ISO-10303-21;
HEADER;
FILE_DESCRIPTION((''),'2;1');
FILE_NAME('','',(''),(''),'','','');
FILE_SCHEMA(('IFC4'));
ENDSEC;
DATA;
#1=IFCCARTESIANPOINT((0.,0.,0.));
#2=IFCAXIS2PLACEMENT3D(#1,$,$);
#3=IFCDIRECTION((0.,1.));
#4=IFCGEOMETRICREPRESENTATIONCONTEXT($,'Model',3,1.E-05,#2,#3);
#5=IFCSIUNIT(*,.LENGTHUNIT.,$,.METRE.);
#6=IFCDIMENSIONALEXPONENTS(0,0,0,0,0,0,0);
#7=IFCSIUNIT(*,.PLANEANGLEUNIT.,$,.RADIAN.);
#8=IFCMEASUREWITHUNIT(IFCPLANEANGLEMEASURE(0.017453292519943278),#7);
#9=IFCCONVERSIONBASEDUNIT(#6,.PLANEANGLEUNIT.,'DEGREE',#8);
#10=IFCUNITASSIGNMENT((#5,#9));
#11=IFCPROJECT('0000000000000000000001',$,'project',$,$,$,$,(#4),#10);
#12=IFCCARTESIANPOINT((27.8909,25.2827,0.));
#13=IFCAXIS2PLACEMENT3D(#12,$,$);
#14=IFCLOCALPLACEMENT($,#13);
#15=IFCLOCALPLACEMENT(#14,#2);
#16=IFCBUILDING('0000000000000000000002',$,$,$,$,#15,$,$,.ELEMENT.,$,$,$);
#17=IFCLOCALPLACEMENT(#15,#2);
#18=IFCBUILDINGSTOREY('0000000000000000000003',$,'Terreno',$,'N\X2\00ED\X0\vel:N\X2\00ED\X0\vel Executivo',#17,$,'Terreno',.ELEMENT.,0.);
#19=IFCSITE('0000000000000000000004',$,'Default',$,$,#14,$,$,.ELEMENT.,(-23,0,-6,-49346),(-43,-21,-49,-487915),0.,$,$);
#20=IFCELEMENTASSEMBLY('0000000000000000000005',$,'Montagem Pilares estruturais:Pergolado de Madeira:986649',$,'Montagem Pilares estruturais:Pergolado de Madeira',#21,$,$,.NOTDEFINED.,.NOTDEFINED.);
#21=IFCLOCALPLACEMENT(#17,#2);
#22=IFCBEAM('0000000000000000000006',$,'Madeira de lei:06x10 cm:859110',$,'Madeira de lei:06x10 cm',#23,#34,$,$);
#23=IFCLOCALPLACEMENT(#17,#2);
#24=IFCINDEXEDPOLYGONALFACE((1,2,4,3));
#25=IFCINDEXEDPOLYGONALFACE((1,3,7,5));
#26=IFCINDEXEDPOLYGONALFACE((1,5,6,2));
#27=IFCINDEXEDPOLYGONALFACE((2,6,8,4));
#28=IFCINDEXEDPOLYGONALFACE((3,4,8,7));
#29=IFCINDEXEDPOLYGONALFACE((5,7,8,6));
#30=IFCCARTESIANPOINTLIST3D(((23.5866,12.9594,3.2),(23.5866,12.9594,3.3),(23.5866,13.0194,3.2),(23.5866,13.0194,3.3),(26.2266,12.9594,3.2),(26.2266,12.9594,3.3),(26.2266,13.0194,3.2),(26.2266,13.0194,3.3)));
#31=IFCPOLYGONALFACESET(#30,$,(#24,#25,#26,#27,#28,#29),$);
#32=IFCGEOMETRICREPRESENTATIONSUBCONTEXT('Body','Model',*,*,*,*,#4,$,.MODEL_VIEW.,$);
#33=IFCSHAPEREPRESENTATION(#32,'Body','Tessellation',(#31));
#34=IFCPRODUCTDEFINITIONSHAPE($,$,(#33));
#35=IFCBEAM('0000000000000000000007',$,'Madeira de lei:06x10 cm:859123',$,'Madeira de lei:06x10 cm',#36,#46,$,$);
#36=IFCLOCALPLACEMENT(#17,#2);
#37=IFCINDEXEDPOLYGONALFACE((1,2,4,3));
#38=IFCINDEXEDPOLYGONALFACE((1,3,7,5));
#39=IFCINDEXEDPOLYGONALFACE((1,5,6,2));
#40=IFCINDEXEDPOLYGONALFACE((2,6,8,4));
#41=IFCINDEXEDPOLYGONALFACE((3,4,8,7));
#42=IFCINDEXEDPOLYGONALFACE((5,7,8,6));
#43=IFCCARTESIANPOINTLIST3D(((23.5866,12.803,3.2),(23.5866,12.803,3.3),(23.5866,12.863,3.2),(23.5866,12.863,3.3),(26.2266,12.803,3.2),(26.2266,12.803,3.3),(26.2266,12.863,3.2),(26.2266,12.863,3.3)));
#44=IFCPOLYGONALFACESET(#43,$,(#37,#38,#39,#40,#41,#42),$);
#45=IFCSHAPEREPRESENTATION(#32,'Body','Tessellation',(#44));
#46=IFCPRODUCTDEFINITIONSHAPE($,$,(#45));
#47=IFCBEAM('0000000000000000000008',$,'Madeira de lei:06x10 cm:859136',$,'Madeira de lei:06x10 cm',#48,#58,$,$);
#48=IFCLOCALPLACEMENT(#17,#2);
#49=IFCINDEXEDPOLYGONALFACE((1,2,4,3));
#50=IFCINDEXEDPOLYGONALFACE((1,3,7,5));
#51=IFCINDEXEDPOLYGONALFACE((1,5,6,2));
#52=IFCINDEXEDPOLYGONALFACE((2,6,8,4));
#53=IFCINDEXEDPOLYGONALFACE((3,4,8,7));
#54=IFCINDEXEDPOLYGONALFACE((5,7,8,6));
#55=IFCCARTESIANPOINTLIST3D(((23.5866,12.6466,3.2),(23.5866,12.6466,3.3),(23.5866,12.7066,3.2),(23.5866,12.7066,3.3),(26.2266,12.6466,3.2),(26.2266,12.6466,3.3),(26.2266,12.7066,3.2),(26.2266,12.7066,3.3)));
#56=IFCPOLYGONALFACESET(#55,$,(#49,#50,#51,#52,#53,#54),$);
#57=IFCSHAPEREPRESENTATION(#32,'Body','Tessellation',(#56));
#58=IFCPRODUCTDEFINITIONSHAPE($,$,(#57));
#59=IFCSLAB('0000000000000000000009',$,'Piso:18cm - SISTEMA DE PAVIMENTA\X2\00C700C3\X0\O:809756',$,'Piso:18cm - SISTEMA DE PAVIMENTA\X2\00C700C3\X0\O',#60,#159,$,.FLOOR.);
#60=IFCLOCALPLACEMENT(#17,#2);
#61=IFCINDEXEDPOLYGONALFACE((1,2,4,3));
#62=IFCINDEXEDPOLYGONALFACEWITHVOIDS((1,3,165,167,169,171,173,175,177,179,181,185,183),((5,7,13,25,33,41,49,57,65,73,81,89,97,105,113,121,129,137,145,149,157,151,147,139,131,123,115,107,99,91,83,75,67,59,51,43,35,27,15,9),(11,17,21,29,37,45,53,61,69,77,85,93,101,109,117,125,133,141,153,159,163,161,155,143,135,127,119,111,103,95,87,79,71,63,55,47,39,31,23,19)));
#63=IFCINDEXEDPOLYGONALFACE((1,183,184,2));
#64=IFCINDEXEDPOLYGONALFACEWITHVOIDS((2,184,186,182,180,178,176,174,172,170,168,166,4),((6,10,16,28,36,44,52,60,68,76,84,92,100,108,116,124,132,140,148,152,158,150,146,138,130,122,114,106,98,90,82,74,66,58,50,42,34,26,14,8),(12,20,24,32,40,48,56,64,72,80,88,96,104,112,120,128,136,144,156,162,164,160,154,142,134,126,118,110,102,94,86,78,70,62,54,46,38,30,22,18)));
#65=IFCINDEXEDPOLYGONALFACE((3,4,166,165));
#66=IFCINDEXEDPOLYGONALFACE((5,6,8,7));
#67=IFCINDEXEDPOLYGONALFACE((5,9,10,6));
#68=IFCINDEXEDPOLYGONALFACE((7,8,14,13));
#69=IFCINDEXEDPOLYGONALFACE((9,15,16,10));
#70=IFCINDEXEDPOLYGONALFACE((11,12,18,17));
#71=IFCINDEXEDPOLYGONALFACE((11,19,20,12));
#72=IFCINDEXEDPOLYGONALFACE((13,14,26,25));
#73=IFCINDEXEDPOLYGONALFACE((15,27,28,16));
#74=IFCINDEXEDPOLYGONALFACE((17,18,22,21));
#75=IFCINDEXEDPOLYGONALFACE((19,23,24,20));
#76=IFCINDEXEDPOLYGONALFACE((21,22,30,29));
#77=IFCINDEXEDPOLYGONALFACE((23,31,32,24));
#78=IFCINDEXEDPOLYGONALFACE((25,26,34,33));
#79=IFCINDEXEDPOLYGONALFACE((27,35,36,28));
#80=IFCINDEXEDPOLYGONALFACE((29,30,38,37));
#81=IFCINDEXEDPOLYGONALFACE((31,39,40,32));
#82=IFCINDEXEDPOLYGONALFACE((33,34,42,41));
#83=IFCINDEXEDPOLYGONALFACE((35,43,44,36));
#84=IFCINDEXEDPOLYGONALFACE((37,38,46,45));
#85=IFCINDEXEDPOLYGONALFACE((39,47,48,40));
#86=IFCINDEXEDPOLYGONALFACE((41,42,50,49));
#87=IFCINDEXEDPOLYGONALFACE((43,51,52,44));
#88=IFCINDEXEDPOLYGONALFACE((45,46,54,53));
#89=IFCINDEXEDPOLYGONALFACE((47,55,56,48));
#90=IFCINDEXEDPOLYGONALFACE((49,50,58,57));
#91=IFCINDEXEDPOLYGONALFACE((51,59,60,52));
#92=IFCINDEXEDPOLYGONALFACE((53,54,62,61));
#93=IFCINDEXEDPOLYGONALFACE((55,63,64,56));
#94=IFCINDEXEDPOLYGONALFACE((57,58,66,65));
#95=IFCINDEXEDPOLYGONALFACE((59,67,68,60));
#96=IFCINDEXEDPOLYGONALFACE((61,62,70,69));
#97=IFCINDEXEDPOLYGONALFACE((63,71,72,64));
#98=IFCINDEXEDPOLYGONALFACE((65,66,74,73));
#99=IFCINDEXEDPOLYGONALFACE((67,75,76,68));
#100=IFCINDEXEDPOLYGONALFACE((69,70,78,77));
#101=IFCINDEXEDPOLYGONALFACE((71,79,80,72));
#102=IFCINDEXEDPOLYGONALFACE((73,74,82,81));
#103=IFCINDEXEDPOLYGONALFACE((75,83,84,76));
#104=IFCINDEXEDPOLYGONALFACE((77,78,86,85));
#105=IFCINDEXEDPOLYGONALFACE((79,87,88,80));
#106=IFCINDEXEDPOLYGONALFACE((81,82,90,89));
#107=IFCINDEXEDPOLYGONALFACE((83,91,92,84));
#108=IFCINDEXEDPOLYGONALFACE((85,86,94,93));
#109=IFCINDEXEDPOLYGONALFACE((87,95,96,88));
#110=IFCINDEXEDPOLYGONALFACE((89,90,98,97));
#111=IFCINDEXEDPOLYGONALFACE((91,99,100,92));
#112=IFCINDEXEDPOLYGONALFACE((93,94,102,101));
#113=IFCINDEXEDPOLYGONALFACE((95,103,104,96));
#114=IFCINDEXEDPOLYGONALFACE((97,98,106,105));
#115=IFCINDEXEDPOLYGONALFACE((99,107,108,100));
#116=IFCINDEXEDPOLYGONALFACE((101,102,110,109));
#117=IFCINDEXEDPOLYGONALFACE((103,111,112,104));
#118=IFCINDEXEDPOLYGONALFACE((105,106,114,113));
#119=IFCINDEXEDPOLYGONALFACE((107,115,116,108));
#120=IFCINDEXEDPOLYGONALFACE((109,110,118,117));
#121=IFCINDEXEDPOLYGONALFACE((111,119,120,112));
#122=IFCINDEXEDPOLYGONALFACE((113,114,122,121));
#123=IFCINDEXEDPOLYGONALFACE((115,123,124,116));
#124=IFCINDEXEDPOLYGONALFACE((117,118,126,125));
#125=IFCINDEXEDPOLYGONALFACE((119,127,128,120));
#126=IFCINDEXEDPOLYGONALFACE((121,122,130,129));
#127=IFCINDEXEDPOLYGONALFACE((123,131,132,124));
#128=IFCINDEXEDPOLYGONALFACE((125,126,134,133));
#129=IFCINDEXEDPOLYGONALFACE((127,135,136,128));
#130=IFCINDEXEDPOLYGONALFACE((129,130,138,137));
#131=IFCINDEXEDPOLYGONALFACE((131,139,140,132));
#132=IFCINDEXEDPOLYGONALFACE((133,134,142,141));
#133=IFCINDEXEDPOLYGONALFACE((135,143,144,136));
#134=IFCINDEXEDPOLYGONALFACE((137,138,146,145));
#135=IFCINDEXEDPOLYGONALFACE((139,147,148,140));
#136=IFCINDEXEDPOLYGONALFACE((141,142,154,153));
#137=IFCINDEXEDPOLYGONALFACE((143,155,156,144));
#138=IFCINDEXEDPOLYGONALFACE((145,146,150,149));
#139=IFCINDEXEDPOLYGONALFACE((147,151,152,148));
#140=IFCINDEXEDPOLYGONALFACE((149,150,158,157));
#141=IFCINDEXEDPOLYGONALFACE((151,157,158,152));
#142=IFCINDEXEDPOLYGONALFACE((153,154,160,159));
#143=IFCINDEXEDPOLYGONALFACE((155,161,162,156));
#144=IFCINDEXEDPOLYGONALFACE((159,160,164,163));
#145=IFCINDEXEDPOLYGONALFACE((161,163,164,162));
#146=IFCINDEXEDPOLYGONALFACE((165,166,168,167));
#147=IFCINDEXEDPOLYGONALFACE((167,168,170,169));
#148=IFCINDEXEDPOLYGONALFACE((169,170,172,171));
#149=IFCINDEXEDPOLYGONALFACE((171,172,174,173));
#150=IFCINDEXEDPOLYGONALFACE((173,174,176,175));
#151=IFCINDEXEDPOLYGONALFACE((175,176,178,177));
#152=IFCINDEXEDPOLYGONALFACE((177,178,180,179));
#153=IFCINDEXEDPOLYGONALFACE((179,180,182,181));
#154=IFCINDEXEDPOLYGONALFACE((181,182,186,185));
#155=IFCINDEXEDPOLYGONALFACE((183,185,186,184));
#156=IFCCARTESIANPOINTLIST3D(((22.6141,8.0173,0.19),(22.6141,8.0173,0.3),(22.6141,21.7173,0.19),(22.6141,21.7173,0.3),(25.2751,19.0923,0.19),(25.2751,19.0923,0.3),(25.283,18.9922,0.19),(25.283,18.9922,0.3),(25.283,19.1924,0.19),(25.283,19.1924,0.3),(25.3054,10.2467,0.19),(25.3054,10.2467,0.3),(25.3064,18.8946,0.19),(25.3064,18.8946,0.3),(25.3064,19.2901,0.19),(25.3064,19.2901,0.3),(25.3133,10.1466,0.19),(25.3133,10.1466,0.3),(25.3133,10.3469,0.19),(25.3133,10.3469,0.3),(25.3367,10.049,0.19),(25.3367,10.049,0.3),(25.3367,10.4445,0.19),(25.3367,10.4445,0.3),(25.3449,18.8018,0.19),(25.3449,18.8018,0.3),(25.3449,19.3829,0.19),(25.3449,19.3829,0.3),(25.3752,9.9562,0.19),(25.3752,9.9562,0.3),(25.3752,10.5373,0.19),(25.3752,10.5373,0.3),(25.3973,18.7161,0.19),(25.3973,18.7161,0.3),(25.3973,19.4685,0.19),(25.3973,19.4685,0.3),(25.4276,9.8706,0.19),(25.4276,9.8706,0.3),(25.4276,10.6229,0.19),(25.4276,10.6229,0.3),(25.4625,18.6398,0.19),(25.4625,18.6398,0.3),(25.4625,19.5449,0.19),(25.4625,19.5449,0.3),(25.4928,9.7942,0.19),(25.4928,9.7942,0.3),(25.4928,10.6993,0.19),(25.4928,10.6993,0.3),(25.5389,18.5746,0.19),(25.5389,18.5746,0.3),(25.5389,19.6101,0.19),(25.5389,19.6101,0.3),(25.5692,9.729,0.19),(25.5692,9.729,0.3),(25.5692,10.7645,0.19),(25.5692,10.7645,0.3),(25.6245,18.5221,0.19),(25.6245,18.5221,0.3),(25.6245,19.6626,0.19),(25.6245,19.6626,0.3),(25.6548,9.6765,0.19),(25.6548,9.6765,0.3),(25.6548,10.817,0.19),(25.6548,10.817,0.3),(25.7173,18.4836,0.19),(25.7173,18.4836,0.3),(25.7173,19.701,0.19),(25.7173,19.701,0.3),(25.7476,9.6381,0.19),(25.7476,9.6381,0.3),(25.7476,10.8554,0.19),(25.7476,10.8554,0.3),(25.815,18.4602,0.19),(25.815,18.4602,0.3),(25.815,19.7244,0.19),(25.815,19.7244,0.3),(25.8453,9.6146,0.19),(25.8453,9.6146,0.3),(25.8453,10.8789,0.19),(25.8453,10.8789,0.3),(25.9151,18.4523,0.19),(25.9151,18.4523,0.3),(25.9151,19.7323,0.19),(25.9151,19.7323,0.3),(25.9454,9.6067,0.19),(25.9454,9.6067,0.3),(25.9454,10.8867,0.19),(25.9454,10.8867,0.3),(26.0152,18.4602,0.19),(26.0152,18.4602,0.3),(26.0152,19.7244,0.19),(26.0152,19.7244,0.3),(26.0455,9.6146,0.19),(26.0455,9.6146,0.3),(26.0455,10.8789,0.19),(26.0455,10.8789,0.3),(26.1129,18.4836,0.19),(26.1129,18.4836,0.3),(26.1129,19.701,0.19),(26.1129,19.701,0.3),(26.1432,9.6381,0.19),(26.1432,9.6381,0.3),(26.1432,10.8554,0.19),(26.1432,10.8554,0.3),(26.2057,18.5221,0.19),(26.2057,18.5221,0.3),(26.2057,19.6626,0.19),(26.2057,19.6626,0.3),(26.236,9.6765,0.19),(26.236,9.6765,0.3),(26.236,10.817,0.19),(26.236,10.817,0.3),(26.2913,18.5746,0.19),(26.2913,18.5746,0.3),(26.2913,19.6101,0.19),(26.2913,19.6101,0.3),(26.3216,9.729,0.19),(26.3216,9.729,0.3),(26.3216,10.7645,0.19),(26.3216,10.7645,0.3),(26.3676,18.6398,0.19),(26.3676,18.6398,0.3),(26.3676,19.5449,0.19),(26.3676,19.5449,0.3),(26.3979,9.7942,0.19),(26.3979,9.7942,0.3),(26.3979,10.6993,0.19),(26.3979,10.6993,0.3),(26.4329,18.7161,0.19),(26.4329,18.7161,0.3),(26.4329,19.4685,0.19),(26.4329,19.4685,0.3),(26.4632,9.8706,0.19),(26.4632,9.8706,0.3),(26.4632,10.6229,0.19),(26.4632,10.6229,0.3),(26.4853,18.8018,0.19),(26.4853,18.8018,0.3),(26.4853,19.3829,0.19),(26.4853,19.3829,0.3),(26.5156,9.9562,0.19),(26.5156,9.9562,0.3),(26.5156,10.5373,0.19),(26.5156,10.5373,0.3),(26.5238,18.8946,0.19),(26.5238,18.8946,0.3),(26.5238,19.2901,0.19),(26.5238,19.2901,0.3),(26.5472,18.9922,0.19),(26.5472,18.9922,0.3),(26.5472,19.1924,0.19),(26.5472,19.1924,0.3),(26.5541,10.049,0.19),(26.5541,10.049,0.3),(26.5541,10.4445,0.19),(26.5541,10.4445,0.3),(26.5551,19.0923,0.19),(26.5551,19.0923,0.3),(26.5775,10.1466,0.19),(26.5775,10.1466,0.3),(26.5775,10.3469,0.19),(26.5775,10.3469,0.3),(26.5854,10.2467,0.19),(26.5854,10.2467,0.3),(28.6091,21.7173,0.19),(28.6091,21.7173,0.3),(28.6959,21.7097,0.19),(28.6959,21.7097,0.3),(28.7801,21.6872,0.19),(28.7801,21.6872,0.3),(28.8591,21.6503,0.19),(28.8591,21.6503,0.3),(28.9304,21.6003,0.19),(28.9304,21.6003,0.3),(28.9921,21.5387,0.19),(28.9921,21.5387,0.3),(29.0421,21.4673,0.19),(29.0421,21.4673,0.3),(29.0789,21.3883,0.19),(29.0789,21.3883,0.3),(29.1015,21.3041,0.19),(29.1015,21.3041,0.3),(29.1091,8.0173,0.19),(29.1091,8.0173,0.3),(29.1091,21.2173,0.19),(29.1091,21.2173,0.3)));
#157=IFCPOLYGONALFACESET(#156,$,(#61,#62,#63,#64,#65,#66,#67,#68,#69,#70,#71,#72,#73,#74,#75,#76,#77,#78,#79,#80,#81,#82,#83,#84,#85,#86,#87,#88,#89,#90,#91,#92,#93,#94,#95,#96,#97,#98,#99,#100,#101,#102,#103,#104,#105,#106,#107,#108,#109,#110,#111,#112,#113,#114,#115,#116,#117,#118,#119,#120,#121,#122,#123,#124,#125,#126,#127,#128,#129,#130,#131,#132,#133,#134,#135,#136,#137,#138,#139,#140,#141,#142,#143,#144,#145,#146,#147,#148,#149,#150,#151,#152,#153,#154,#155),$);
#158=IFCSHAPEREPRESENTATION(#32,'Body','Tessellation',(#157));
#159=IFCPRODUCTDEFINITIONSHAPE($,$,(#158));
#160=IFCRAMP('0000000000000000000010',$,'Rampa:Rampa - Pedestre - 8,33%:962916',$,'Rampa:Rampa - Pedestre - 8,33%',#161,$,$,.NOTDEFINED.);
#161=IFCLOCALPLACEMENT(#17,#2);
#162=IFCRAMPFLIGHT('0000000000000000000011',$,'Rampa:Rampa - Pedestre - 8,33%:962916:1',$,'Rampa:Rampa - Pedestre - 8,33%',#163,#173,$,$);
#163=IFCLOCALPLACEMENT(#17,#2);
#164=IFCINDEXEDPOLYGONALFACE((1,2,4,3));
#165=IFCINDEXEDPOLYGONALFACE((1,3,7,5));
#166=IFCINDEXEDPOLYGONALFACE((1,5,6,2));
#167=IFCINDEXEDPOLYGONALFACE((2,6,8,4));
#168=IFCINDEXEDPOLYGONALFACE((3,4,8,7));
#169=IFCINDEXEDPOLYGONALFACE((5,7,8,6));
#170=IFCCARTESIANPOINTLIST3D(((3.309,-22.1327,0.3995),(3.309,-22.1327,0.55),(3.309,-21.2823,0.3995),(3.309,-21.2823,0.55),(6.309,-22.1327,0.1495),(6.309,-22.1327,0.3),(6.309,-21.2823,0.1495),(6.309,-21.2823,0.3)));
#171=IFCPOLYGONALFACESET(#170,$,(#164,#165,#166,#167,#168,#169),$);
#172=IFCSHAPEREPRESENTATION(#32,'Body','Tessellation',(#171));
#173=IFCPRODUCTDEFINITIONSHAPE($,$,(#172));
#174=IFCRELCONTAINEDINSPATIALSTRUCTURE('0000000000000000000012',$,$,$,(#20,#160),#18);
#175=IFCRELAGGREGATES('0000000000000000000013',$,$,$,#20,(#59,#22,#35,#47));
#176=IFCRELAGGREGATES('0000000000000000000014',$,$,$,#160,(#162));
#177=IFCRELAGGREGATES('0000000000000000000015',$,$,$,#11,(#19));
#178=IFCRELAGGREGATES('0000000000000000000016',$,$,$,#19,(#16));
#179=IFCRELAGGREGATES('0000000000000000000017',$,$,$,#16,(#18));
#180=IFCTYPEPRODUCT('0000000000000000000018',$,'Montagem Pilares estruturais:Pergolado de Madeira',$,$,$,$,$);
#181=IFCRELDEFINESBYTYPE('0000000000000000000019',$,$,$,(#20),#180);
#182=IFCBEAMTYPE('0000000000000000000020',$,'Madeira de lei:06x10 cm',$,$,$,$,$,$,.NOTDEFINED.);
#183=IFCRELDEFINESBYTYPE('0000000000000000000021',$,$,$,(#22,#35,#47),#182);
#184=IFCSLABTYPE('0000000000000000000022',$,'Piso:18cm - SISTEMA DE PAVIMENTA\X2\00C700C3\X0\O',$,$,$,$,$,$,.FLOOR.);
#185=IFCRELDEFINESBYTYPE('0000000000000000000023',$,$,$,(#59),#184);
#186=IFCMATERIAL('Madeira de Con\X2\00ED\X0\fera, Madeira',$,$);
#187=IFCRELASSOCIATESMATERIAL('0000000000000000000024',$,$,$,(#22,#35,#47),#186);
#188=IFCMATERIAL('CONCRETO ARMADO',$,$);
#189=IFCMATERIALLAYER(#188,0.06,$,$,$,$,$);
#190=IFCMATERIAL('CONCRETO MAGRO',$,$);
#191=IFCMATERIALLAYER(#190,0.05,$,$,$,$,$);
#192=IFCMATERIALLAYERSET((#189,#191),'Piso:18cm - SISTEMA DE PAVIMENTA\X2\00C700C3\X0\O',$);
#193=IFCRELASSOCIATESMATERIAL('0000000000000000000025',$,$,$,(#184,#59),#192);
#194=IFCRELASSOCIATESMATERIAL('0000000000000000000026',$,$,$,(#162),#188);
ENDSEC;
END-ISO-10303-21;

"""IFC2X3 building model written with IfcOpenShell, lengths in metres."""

from ifc_helpers import new_model, entity, si_unit, converted_unit, direction, frame, frame_2d, origin, origin_2d_with_axis, place, context, subcontext, project, spatial, polyline, circle_curve, parameter, trimmed, segment, composite_curve, rectangle, circle, outline, extrude, material, layer, layer_set, layer_usage, type_object, element, aggregate, save


model = new_model("IFC2X3")

# Units and contexts
model_context = context("Model", 3, precision=1e-05, world=origin(), true_north=direction((0.0, 1.0)))
body_context = subcontext(model_context, "Body", "Model", "MODEL_VIEW")
ifc_project = project(units=[si_unit("LENGTHUNIT", "METRE"), converted_unit("PLANEANGLEUNIT", "DEGREE", entity("IfcPlaneAngleMeasure", 0.017453292519943278), si_unit("PLANEANGLEUNIT", "RADIAN"), dimensions=[0, 0, 0, 0, 0, 0, 0])], contexts=[model_context])

# Site, building, storey
site_placement = place(None, frame((27.8909, 25.2827, 0.0)))
site = spatial("IfcSite", under=ifc_project, at=site_placement, Name="Default", CompositionType="ELEMENT", RefLatitude=(-23, 0, -6, -49346), RefLongitude=(-43, -21, -49, -487915), RefElevation=0.0)
building_placement = place(site_placement, origin())
building = spatial("IfcBuilding", under=site, at=building_placement, CompositionType="ELEMENT")
storey_placement = place(building_placement, origin())
storey = spatial("IfcBuildingStorey", under=building, at=storey_placement, Name="Terreno", ObjectType="Nível:Nível Executivo", LongName="Terreno", CompositionType="ELEMENT", Elevation=0.0)

# Element assembly, beams, slab, openings
type_product = type_object("IfcTypeProduct", Name="Montagem Pilares estruturais:Pergolado de Madeira")
assembly_placement = place(storey_placement, origin())
assembly = element("IfcElementAssembly", 1, at=assembly_placement, inside=storey, type_object=type_product, Name="Montagem Pilares estruturais:Pergolado de Madeira:986649", ObjectType="Montagem Pilares estruturais:Pergolado de Madeira", AssemblyPlace="NOTDEFINED", PredefinedType="NOTDEFINED")
ifc_material_1 = material(Name="Madeira de Conífera, Madeira")
beam_type_1 = type_object("IfcBeamType", Name="Madeira de lei:06x10 cm", PredefinedType="NOTDEFINED")
beam_1_placement = place(assembly_placement, frame((23.5866, 12.9894, 3.2)))
beam_1 = element("IfcBeam", 2, at=beam_1_placement, type_object=beam_type_1, material=ifc_material_1, Name="Madeira de lei:06x10 cm:859110", ObjectType="Madeira de lei:06x10 cm", context=body_context, shape_type="SweptSolid", body=[
    extrude(rectangle(XDim=0.1, YDim=0.06, at=frame_2d((0.0, 0.0), x_axis=(1.0, 0.0))), frame((0.0, 0.0, 0.05), z_axis=(1.0, 0.0, 0.0), x_axis=(0.0, 0.0, -1.0)), (0.0, 0.0, 1.0), 2.64),
])
beam_2_placement = place(assembly_placement, frame((23.5866, 12.833, 3.2)))
beam_2 = element("IfcBeam", 3, at=beam_2_placement, type_object=beam_type_1, material=ifc_material_1, Name="Madeira de lei:06x10 cm:859123", ObjectType="Madeira de lei:06x10 cm", context=body_context, shape_type="SweptSolid", body=[
    extrude(rectangle(XDim=0.1, YDim=0.06, at=frame_2d((0.0, 0.0), x_axis=(1.0, 0.0))), frame((0.0, 0.0, 0.05), z_axis=(1.0, 0.0, 0.0), x_axis=(0.0, 0.0, -1.0)), (0.0, 0.0, 1.0), 2.64),
])
beam_3_placement = place(assembly_placement, frame((23.5866, 12.6766, 3.2)))
beam_3 = element("IfcBeam", 4, at=beam_3_placement, type_object=beam_type_1, material=ifc_material_1, Name="Madeira de lei:06x10 cm:859136", ObjectType="Madeira de lei:06x10 cm", context=body_context, shape_type="SweptSolid", body=[
    extrude(rectangle(XDim=0.1, YDim=0.06, at=frame_2d((0.0, 0.0), x_axis=(1.0, 0.0))), frame((0.0, 0.0, 0.05), z_axis=(1.0, 0.0, 0.0), x_axis=(0.0, 0.0, -1.0)), (0.0, 0.0, 1.0), 2.64),
])
ifc_material_2 = material(Name="CONCRETO ARMADO")
ifc_layer_1 = layer(ifc_material_2, 0.06)
ifc_material_3 = material(Name="CONCRETO MAGRO")
ifc_layer_2 = layer(ifc_material_3, 0.05)
ifc_layer_set = layer_set([ifc_layer_1, ifc_layer_2], Name="Piso:18cm - SISTEMA DE PAVIMENTAÇÃO")
ifc_layer_usage = layer_usage(ifc_layer_set, "AXIS3", "POSITIVE", 0.0)
slab_type = type_object("IfcSlabType", Name="Piso:18cm - SISTEMA DE PAVIMENTAÇÃO", PredefinedType="FLOOR", material=ifc_layer_set)
slab_placement = place(assembly_placement, frame((22.6141, 8.0173, 0.19)))
slab = element("IfcSlab", 5, at=slab_placement, type_object=slab_type, material=ifc_layer_usage, Name="Piso:18cm - SISTEMA DE PAVIMENTAÇÃO:809756", ObjectType="Piso:18cm - SISTEMA DE PAVIMENTAÇÃO", PredefinedType="FLOOR", context=body_context, shape_type="SweptSolid", body=[
    extrude(outline(composite_curve([segment(trimmed(circle_curve(frame_2d((-2.7475, 6.35), x_axis=(-1.0, 0.0)), 0.5), [parameter(270.0)], [parameter(0.0)], True, "PARAMETER"), True, "CONTINUOUS"), segment(polyline([(-3.2475, 6.35), (-3.2475, -6.85)]), True, "CONTINUOUS"), segment(polyline([(-3.2475, -6.85), (3.2475, -6.85)]), True, "CONTINUOUS"), segment(polyline([(3.2475, -6.85), (3.2475, 6.85)]), True, "CONTINUOUS"), segment(polyline([(3.2475, 6.85), (-2.7475, 6.85)]), True, "CONTINUOUS")], self_intersect=False)), frame((3.2475, 6.85, 0.11), z_axis=(0.0, 0.0, -1.0), x_axis=(-1.0, 0.0, 0.0)), (0.0, 0.0, 1.0), 0.11),
])
opening_1_placement = place(assembly_placement, frame((22.6141, 8.0173, 0.19)))
opening_1 = element("IfcOpeningElement", 6, at=opening_1_placement, cuts=slab, ObjectType="Opening", context=body_context, shape_type="SweptSolid", body=[
    extrude(circle(Radius=0.64, at=origin_2d_with_axis()), frame((3.3313, 2.2294, 0.11), z_axis=(0.0, 0.0, -1.0), x_axis=(1.0, 0.0, 0.0)), (0.0, 0.0, 1.0), 0.11),
])
opening_2_placement = place(assembly_placement, frame((22.6141, 8.0173, 0.19)))
opening_2 = element("IfcOpeningElement", 7, at=opening_2_placement, cuts=slab, ObjectType="Opening", context=body_context, shape_type="SweptSolid", body=[
    extrude(circle(Radius=0.64, at=origin_2d_with_axis()), frame((3.301, 11.075, 0.11), z_axis=(0.0, 0.0, -1.0), x_axis=(1.0, 0.0, 0.0)), (0.0, 0.0, 1.0), 0.11),
])
aggregate(assembly, [slab, opening_1, opening_2, beam_1, beam_2, beam_3])

# Ramp, ramp flight
ramp_placement = place(storey_placement, origin())
ramp = element("IfcRamp", 8, at=ramp_placement, inside=storey, Name="Rampa:Rampa - Pedestre - 8,33%:962916", ObjectType="Rampa:Rampa - Pedestre - 8,33%", ShapeType="NOTDEFINED")
ramp_flight_placement = place(ramp_placement, origin())
ramp_flight = element("IfcRampFlight", 9, at=ramp_flight_placement, material=ifc_material_2, Name="Rampa:Rampa - Pedestre - 8,33%:962916:1", ObjectType="Rampa:Rampa - Pedestre - 8,33%", context=body_context, shape_type="SweptSolid", body=[
    extrude(outline(polyline([(0.0497, -1.5), (0.2003, -1.5), (-0.0497, 1.5), (-0.2003, 1.5), (0.0497, -1.5)])), frame((4.809, -22.1327, 0.3497), z_axis=(0.0, 1.0, 0.0), x_axis=(0.0, 0.0, -1.0)), (0.0, 0.0, 1.0), 0.8504),
])
aggregate(ramp, [ramp_flight])

save(model, "model.ifc")
